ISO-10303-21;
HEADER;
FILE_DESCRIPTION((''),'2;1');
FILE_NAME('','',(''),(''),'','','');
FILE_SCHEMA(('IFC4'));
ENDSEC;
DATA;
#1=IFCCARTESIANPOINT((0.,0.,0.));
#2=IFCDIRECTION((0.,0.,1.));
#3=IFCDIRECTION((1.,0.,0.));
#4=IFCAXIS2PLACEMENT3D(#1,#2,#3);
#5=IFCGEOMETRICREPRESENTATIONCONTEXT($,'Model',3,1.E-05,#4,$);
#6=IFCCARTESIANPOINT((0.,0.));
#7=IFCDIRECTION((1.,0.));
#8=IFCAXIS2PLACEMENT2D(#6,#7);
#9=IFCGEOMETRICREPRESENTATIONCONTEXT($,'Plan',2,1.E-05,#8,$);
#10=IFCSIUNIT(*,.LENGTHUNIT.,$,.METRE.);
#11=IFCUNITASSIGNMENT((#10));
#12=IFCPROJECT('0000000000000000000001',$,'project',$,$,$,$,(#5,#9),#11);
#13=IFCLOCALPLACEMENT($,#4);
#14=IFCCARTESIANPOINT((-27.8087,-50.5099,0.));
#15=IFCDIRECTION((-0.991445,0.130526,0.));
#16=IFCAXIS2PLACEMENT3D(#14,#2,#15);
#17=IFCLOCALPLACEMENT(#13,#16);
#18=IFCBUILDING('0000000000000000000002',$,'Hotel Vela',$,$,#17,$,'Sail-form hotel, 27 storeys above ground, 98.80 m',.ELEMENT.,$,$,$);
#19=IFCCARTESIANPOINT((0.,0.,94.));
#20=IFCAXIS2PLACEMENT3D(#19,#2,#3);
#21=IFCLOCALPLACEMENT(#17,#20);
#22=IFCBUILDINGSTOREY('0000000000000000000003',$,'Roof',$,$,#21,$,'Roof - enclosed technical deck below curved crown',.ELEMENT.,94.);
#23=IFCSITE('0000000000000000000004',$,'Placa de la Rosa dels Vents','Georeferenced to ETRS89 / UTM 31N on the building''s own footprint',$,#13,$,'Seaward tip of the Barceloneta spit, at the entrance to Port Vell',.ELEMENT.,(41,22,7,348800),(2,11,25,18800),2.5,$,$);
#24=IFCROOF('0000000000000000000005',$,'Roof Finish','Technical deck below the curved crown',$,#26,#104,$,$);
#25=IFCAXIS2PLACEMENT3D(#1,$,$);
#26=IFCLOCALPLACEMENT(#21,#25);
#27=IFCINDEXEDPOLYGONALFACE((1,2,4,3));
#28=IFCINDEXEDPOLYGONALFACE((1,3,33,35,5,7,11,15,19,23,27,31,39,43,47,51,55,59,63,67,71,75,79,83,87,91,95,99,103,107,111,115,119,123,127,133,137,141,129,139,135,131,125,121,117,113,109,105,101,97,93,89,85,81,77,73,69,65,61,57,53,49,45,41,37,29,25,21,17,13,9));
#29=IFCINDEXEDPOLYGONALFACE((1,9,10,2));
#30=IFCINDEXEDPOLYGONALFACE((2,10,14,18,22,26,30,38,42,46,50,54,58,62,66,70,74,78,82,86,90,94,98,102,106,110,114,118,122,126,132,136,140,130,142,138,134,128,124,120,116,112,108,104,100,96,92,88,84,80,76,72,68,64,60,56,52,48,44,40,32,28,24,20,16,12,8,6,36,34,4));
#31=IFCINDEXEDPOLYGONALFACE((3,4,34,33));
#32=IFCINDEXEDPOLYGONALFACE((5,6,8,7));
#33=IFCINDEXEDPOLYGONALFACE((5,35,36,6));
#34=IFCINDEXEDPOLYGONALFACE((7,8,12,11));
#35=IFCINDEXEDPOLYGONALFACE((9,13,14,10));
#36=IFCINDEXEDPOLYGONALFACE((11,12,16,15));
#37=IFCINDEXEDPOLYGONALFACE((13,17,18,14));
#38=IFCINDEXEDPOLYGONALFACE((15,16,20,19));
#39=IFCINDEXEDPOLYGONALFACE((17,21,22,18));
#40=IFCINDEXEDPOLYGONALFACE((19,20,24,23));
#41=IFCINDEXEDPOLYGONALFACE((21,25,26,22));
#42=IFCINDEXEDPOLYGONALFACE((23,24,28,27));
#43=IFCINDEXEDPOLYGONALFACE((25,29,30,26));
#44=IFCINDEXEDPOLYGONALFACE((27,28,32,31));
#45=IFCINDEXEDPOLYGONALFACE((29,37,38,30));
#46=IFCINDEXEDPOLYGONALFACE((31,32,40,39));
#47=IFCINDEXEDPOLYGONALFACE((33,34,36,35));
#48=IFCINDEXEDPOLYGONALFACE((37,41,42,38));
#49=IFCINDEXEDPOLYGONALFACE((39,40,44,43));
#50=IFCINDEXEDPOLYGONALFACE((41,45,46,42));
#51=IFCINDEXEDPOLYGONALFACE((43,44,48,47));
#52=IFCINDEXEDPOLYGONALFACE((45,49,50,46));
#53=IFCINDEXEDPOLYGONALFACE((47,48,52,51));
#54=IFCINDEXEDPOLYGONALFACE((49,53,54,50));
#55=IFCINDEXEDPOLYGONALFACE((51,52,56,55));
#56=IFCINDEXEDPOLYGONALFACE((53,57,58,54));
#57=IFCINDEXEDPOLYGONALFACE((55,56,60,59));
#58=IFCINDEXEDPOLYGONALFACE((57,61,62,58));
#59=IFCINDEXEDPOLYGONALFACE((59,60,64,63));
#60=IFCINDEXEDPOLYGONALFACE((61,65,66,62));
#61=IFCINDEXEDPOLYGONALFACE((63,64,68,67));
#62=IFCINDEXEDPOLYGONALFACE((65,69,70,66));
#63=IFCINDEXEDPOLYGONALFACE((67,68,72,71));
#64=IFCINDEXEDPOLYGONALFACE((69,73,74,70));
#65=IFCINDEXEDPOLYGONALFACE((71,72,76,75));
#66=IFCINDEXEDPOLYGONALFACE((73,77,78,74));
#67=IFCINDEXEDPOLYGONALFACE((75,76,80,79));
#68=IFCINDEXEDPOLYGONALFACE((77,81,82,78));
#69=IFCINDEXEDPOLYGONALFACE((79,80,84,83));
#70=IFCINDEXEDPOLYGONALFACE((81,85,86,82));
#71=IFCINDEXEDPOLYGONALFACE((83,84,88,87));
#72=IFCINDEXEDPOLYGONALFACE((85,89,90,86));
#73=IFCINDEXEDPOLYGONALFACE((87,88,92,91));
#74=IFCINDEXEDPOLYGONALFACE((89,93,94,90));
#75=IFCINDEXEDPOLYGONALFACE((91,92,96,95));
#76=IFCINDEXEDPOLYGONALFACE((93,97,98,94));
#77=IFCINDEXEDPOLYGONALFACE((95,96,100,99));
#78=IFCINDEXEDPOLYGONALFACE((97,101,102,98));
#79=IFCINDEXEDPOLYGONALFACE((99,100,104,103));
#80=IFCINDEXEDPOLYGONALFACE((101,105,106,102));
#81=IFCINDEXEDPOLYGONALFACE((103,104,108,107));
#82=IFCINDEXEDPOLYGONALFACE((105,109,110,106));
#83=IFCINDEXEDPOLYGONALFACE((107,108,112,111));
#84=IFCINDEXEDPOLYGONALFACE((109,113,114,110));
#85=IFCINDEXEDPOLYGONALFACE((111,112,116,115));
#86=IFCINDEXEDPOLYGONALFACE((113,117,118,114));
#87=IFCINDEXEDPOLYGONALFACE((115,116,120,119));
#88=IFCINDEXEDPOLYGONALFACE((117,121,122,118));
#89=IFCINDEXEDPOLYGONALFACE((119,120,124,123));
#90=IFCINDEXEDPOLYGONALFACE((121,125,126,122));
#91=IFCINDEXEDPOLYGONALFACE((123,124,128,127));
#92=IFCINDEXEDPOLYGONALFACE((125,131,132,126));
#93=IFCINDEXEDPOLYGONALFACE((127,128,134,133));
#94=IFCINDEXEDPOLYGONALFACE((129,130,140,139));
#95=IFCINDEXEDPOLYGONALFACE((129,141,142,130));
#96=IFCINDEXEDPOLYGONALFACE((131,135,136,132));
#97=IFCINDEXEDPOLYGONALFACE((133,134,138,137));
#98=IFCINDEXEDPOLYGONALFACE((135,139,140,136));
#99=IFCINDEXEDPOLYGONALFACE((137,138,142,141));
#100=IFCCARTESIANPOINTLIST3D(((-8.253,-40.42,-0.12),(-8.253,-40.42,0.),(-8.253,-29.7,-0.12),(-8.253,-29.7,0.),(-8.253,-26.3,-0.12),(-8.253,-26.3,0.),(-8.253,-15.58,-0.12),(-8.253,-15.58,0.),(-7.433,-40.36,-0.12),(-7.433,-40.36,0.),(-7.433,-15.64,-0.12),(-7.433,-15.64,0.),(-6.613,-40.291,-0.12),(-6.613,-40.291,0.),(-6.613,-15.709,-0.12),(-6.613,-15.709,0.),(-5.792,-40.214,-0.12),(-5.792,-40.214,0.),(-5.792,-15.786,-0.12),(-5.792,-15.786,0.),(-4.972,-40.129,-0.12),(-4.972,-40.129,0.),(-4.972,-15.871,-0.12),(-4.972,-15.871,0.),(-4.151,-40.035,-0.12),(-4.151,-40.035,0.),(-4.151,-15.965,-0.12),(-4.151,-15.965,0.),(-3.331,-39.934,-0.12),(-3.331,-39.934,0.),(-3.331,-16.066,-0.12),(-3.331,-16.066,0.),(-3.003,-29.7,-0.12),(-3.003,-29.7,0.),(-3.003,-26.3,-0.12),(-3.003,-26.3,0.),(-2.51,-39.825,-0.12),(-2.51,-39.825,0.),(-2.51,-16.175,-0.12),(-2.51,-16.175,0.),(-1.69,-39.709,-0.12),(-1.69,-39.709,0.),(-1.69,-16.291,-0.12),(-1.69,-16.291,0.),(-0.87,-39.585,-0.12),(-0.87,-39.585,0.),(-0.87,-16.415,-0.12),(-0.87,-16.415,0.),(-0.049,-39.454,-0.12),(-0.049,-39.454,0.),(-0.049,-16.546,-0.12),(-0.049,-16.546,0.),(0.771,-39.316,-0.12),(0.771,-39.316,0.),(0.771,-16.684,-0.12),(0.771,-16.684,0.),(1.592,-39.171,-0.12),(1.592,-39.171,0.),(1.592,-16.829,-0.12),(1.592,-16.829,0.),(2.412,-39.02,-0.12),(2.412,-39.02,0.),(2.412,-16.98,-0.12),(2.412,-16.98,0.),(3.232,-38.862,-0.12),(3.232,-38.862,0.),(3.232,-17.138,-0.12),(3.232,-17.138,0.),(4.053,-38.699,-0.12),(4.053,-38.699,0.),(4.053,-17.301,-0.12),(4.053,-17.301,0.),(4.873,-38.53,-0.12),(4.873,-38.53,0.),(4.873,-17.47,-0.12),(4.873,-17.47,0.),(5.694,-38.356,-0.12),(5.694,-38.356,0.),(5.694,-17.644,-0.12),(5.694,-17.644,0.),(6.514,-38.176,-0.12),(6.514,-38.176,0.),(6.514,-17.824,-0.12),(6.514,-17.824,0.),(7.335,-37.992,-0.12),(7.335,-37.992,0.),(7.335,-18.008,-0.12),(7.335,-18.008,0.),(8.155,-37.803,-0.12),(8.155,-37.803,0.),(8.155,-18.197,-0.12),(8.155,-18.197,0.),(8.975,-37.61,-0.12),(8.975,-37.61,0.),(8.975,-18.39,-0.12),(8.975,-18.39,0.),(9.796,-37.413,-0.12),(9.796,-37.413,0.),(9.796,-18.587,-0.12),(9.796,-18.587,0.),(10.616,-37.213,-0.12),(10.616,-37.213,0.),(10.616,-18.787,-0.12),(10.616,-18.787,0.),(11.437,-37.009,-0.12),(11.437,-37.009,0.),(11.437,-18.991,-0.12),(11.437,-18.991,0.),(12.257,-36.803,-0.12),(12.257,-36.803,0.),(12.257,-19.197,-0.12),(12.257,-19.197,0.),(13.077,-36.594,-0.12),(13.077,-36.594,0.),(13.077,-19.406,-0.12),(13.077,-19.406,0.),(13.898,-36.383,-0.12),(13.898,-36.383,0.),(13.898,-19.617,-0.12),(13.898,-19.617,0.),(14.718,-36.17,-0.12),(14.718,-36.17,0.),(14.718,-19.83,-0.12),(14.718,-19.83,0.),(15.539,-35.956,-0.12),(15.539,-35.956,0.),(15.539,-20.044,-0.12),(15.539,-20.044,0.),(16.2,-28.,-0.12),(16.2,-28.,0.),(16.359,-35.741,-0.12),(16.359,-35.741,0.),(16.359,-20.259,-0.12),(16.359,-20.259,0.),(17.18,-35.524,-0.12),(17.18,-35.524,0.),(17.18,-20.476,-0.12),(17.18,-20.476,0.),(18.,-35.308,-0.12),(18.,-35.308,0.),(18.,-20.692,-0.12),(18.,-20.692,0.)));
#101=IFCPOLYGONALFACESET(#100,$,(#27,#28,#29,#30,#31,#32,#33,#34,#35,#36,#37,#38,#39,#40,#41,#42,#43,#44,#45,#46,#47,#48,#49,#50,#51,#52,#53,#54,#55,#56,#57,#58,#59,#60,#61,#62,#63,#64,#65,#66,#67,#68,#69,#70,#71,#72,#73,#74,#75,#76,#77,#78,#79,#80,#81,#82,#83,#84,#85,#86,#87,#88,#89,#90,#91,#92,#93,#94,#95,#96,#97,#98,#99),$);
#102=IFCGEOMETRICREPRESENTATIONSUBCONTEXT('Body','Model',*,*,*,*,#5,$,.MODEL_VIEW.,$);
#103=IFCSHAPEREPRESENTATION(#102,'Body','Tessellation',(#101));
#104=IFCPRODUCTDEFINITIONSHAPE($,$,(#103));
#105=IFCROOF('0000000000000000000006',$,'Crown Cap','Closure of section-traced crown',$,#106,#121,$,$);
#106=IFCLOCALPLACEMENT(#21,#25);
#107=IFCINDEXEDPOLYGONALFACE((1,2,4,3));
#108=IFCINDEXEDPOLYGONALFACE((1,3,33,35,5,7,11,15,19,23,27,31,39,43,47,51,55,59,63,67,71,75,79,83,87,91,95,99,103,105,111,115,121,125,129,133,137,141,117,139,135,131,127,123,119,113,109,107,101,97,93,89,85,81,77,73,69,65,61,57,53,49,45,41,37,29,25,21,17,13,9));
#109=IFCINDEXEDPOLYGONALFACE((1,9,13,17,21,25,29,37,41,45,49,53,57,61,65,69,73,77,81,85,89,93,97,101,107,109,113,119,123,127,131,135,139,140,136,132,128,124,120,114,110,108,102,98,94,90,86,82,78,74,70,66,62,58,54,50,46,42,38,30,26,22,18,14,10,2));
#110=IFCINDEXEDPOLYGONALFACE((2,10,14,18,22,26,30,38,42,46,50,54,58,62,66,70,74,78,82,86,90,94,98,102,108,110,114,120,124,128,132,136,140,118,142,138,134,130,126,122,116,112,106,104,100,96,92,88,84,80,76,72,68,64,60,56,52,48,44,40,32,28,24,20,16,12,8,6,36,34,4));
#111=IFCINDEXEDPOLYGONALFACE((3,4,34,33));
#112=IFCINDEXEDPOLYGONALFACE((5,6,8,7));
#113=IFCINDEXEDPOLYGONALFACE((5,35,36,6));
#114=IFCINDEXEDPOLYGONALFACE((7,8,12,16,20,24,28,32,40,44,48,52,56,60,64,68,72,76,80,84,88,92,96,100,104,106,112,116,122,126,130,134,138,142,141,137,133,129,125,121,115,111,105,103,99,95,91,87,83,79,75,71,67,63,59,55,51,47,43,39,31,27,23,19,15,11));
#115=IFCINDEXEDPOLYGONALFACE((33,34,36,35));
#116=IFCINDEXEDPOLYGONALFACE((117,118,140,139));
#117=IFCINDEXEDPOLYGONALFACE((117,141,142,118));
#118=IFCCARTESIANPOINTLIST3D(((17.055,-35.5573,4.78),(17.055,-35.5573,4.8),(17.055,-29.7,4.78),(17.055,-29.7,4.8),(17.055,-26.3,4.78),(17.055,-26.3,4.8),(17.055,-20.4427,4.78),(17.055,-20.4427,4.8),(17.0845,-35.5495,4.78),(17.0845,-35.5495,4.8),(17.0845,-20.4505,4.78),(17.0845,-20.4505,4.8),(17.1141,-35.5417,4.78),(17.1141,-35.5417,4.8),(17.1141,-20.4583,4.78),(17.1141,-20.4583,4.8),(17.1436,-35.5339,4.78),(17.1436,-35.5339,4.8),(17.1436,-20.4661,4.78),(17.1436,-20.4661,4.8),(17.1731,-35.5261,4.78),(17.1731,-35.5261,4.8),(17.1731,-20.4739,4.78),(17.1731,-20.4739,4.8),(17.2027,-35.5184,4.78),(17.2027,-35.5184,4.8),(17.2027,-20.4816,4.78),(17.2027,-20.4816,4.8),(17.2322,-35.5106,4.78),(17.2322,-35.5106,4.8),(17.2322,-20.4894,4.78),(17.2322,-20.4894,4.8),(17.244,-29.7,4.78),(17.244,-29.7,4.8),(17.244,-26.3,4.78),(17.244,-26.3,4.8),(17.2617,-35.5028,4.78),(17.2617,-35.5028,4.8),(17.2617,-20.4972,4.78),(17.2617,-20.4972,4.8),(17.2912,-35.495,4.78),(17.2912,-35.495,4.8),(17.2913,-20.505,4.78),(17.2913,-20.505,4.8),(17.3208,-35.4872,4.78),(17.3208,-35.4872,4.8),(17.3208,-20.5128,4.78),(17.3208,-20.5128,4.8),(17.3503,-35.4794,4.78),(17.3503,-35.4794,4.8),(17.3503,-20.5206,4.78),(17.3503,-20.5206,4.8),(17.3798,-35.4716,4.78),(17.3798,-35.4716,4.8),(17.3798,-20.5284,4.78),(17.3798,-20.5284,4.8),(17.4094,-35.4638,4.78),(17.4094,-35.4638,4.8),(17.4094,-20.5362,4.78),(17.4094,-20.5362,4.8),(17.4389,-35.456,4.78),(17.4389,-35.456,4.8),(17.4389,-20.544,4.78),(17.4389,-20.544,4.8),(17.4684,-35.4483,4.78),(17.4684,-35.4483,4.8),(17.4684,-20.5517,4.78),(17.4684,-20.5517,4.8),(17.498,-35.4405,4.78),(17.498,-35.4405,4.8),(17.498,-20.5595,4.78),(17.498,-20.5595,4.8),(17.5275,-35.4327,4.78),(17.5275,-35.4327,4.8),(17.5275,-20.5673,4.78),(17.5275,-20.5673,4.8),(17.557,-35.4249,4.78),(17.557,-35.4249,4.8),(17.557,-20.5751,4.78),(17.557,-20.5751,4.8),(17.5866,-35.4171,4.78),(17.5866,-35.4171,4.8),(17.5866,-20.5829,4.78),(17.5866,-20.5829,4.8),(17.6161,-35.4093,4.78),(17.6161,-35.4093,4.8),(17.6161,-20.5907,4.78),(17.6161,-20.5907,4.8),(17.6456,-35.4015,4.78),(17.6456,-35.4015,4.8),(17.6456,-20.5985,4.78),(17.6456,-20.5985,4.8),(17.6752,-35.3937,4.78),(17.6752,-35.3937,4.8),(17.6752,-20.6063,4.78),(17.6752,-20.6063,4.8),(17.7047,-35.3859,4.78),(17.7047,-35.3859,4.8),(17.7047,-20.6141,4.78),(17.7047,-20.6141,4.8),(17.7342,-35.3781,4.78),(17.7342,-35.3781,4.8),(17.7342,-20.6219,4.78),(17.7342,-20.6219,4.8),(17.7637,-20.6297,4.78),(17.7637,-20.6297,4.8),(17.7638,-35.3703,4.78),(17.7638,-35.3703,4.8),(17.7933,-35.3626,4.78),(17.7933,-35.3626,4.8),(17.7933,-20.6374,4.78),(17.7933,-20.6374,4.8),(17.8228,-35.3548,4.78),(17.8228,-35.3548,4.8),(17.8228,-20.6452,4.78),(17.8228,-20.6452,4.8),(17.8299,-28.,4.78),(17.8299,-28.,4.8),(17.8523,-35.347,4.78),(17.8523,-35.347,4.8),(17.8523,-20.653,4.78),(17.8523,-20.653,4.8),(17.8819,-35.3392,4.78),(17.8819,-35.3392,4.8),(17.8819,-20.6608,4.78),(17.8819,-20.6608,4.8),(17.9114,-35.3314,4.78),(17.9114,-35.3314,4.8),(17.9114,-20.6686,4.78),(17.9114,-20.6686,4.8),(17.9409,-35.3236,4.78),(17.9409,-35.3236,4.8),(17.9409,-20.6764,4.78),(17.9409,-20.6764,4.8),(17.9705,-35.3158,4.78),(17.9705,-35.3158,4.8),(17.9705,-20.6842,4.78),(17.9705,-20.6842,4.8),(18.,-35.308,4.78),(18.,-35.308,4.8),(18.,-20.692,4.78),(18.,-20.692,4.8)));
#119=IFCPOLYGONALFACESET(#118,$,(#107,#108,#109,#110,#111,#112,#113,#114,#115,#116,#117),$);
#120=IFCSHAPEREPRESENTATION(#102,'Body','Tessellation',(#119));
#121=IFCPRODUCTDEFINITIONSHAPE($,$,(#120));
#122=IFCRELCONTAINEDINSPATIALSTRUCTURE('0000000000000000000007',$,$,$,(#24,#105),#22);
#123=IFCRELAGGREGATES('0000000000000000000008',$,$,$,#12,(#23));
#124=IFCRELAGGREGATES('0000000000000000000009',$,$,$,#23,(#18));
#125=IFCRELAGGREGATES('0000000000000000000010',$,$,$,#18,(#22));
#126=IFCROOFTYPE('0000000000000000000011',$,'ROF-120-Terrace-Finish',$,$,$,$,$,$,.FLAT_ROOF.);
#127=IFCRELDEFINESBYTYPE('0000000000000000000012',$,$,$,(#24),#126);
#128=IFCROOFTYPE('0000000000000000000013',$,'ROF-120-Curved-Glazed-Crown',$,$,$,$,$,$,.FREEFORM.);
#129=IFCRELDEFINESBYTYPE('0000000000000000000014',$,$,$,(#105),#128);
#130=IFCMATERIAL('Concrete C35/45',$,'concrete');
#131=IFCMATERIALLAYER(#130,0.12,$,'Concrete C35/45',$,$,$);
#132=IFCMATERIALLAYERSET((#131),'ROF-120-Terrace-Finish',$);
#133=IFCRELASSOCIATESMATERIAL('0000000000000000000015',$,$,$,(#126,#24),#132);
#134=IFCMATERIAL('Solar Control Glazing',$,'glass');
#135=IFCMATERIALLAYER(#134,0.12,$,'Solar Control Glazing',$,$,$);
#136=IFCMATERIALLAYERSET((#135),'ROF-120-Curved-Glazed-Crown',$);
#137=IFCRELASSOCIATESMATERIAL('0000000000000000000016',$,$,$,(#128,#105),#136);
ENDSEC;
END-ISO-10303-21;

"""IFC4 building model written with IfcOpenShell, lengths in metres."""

from ifc_helpers import new_model, si_unit, frame, origin_with_axes, origin_2d_with_axis, place, context, subcontext, project, spatial, line, indexed_curve, outline, extrude, material, layer, layer_set, layer_usage, type_object, element, save


model = new_model("IFC4")

# Units and contexts
model_context = context("Model", 3, precision=1e-05, world=origin_with_axes())
plan_context = context("Plan", 2, precision=1e-05, world=origin_2d_with_axis())
body_context = subcontext(model_context, "Body", "Model", "MODEL_VIEW")
ifc_project = project(units=[si_unit("LENGTHUNIT", "METRE")], contexts=[model_context, plan_context])

# Site, building, storey
site_placement = place(None, origin_with_axes())
site = spatial("IfcSite", under=ifc_project, at=site_placement, Name="Placa de la Rosa dels Vents", Description="Georeferenced to ETRS89 / UTM 31N on the building's own footprint", LongName="Seaward tip of the Barceloneta spit, at the entrance to Port Vell", CompositionType="ELEMENT", RefLatitude=(41, 22, 7, 348800), RefLongitude=(2, 11, 25, 18800), RefElevation=2.5)
building_placement = place(site_placement, frame((-27.8087, -50.5099, 0.0), z_axis=(0.0, 0.0, 1.0), x_axis=(-0.991445, 0.130526, 0.0)))
building = spatial("IfcBuilding", under=site, at=building_placement, Name="Hotel Vela", LongName="Sail-form hotel, 27 storeys above ground, 98.80 m", CompositionType="ELEMENT")
storey_placement = place(building_placement, frame((0.0, 0.0, 94.0), z_axis=(0.0, 0.0, 1.0), x_axis=(1.0, 0.0, 0.0)))
storey = spatial("IfcBuildingStorey", under=building, at=storey_placement, Name="Roof", LongName="Roof - enclosed technical deck below curved crown", CompositionType="ELEMENT", Elevation=94.0)

# Roofs
ifc_material_1 = material(Name="Concrete C35/45", Category="concrete")
ifc_layer_1 = layer(ifc_material_1, 0.12, Name="Concrete C35/45")
ifc_layer_set_1 = layer_set([ifc_layer_1], Name="ROF-120-Terrace-Finish")
ifc_layer_usage_1 = layer_usage(ifc_layer_set_1, "AXIS3", "POSITIVE", 0.0)
roof_type_1 = type_object("IfcRoofType", Name="ROF-120-Terrace-Finish", PredefinedType="FLAT_ROOF", material=ifc_layer_set_1)
roof_1_placement = place(storey_placement, frame((0.0, 0.0, -0.12), z_axis=(0.0, 0.0, 1.0), x_axis=(1.0, 0.0, 0.0)))
element("IfcRoof", 1, at=roof_1_placement, inside=storey, type_object=roof_type_1, material=ifc_layer_usage_1, Name="Roof Finish", Description="Technical deck below the curved crown", context=body_context, shape_type="SweptSolid", body=[
    extrude(outline(indexed_curve([(-8.253, -40.42), (-7.433, -40.36), (-6.613, -40.291), (-5.792, -40.214), (-4.972, -40.129), (-4.151, -40.035), (-3.331, -39.934), (-2.51, -39.825), (-1.69, -39.709), (-0.87, -39.585), (-0.049, -39.454), (0.771, -39.316), (1.592, -39.171), (2.412, -39.02), (3.232, -38.862), (4.053, -38.699), (4.873, -38.53), (5.694, -38.356), (6.514, -38.176), (7.335, -37.992), (8.155, -37.803), (8.975, -37.61), (9.796, -37.413), (10.616, -37.213), (11.437, -37.009), (12.257, -36.803), (13.077, -36.594), (13.898, -36.383), (14.718, -36.17), (15.539, -35.956), (16.359, -35.741), (17.18, -35.524), (18.0, -35.308), (16.2, -28.0), (18.0, -20.692), (17.18, -20.476), (16.359, -20.259), (15.539, -20.044), (14.718, -19.83), (13.898, -19.617), (13.077, -19.406), (12.257, -19.197), (11.437, -18.991), (10.616, -18.787), (9.796, -18.587), (8.975, -18.39), (8.155, -18.197), (7.335, -18.008), (6.514, -17.824), (5.694, -17.644), (4.873, -17.47), (4.053, -17.301), (3.232, -17.138), (2.412, -16.98), (1.592, -16.829), (0.771, -16.684), (-0.049, -16.546), (-0.87, -16.415), (-1.69, -16.291), (-2.51, -16.175), (-3.331, -16.066), (-4.151, -15.965), (-4.972, -15.871), (-5.792, -15.786), (-6.613, -15.709), (-7.433, -15.64), (-8.253, -15.58), (-8.253, -26.3), (-3.003, -26.3), (-3.003, -29.7), (-8.253, -29.7)], segments=[line(1, 2, 3, 4, 5, 6, 7, 8, 9, 10, 11, 12, 13, 14, 15, 16, 17, 18, 19, 20, 21, 22, 23, 24, 25, 26, 27, 28, 29, 30, 31, 32, 33, 34, 35, 36, 37, 38, 39, 40, 41, 42, 43, 44, 45, 46, 47, 48, 49, 50, 51, 52, 53, 54, 55, 56, 57, 58, 59, 60, 61, 62, 63, 64, 65, 66, 67, 68, 69, 70, 71, 1)])), origin_with_axes(), (0.0, 0.0, 1.0), 0.12),
])
ifc_material_2 = material(Name="Solar Control Glazing", Category="glass")
ifc_layer_2 = layer(ifc_material_2, 0.12, Name="Solar Control Glazing")
ifc_layer_set_2 = layer_set([ifc_layer_2], Name="ROF-120-Curved-Glazed-Crown")
ifc_layer_usage_2 = layer_usage(ifc_layer_set_2, "AXIS3", "POSITIVE", 0.0)
roof_type_2 = type_object("IfcRoofType", Name="ROF-120-Curved-Glazed-Crown", PredefinedType="FREEFORM", material=ifc_layer_set_2)
roof_2_placement = place(storey_placement, frame((0.0, 0.0, 4.78), z_axis=(0.0, 0.0, 1.0), x_axis=(1.0, 0.0, 0.0)))
element("IfcRoof", 2, at=roof_2_placement, inside=storey, type_object=roof_type_2, material=ifc_layer_usage_2, Name="Crown Cap", Description="Closure of section-traced crown", context=body_context, shape_type="SweptSolid", body=[
    extrude(outline(indexed_curve([(17.055, -35.5573), (17.0845, -35.5495), (17.1141, -35.5417), (17.1436, -35.5339), (17.1731, -35.5261), (17.2027, -35.5184), (17.2322, -35.5106), (17.2617, -35.5028), (17.2913, -35.495), (17.3208, -35.4872), (17.3503, -35.4794), (17.3798, -35.4716), (17.4094, -35.4638), (17.4389, -35.456), (17.4684, -35.4483), (17.498, -35.4405), (17.5275, -35.4327), (17.557, -35.4249), (17.5866, -35.4171), (17.6161, -35.4093), (17.6456, -35.4015), (17.6752, -35.3937), (17.7047, -35.3859), (17.7342, -35.3781), (17.7637, -35.3703), (17.7933, -35.3626), (17.8228, -35.3548), (17.8523, -35.347), (17.8819, -35.3392), (17.9114, -35.3314), (17.9409, -35.3236), (17.9705, -35.3158), (18.0, -35.308), (17.8299, -28.0), (18.0, -20.692), (17.9705, -20.6842), (17.9409, -20.6764), (17.9114, -20.6686), (17.8819, -20.6608), (17.8523, -20.653), (17.8228, -20.6452), (17.7933, -20.6374), (17.7637, -20.6297), (17.7342, -20.6219), (17.7047, -20.6141), (17.6752, -20.6063), (17.6456, -20.5985), (17.6161, -20.5907), (17.5866, -20.5829), (17.557, -20.5751), (17.5275, -20.5673), (17.498, -20.5595), (17.4684, -20.5517), (17.4389, -20.544), (17.4094, -20.5362), (17.3798, -20.5284), (17.3503, -20.5206), (17.3208, -20.5128), (17.2913, -20.505), (17.2617, -20.4972), (17.2322, -20.4894), (17.2027, -20.4816), (17.1731, -20.4739), (17.1436, -20.4661), (17.1141, -20.4583), (17.0845, -20.4505), (17.055, -20.4427), (17.055, -26.3), (17.244, -26.3), (17.244, -29.7), (17.055, -29.7)], segments=[line(1, 2, 3, 4, 5, 6, 7, 8, 9, 10, 11, 12, 13, 14, 15, 16, 17, 18, 19, 20, 21, 22, 23, 24, 25, 26, 27, 28, 29, 30, 31, 32, 33, 34, 35, 36, 37, 38, 39, 40, 41, 42, 43, 44, 45, 46, 47, 48, 49, 50, 51, 52, 53, 54, 55, 56, 57, 58, 59, 60, 61, 62, 63, 64, 65, 66, 67, 68, 69, 70, 71, 1)])), origin_with_axes(), (0.0, 0.0, 1.0), 0.02),
])

save(model, "model.ifc")
